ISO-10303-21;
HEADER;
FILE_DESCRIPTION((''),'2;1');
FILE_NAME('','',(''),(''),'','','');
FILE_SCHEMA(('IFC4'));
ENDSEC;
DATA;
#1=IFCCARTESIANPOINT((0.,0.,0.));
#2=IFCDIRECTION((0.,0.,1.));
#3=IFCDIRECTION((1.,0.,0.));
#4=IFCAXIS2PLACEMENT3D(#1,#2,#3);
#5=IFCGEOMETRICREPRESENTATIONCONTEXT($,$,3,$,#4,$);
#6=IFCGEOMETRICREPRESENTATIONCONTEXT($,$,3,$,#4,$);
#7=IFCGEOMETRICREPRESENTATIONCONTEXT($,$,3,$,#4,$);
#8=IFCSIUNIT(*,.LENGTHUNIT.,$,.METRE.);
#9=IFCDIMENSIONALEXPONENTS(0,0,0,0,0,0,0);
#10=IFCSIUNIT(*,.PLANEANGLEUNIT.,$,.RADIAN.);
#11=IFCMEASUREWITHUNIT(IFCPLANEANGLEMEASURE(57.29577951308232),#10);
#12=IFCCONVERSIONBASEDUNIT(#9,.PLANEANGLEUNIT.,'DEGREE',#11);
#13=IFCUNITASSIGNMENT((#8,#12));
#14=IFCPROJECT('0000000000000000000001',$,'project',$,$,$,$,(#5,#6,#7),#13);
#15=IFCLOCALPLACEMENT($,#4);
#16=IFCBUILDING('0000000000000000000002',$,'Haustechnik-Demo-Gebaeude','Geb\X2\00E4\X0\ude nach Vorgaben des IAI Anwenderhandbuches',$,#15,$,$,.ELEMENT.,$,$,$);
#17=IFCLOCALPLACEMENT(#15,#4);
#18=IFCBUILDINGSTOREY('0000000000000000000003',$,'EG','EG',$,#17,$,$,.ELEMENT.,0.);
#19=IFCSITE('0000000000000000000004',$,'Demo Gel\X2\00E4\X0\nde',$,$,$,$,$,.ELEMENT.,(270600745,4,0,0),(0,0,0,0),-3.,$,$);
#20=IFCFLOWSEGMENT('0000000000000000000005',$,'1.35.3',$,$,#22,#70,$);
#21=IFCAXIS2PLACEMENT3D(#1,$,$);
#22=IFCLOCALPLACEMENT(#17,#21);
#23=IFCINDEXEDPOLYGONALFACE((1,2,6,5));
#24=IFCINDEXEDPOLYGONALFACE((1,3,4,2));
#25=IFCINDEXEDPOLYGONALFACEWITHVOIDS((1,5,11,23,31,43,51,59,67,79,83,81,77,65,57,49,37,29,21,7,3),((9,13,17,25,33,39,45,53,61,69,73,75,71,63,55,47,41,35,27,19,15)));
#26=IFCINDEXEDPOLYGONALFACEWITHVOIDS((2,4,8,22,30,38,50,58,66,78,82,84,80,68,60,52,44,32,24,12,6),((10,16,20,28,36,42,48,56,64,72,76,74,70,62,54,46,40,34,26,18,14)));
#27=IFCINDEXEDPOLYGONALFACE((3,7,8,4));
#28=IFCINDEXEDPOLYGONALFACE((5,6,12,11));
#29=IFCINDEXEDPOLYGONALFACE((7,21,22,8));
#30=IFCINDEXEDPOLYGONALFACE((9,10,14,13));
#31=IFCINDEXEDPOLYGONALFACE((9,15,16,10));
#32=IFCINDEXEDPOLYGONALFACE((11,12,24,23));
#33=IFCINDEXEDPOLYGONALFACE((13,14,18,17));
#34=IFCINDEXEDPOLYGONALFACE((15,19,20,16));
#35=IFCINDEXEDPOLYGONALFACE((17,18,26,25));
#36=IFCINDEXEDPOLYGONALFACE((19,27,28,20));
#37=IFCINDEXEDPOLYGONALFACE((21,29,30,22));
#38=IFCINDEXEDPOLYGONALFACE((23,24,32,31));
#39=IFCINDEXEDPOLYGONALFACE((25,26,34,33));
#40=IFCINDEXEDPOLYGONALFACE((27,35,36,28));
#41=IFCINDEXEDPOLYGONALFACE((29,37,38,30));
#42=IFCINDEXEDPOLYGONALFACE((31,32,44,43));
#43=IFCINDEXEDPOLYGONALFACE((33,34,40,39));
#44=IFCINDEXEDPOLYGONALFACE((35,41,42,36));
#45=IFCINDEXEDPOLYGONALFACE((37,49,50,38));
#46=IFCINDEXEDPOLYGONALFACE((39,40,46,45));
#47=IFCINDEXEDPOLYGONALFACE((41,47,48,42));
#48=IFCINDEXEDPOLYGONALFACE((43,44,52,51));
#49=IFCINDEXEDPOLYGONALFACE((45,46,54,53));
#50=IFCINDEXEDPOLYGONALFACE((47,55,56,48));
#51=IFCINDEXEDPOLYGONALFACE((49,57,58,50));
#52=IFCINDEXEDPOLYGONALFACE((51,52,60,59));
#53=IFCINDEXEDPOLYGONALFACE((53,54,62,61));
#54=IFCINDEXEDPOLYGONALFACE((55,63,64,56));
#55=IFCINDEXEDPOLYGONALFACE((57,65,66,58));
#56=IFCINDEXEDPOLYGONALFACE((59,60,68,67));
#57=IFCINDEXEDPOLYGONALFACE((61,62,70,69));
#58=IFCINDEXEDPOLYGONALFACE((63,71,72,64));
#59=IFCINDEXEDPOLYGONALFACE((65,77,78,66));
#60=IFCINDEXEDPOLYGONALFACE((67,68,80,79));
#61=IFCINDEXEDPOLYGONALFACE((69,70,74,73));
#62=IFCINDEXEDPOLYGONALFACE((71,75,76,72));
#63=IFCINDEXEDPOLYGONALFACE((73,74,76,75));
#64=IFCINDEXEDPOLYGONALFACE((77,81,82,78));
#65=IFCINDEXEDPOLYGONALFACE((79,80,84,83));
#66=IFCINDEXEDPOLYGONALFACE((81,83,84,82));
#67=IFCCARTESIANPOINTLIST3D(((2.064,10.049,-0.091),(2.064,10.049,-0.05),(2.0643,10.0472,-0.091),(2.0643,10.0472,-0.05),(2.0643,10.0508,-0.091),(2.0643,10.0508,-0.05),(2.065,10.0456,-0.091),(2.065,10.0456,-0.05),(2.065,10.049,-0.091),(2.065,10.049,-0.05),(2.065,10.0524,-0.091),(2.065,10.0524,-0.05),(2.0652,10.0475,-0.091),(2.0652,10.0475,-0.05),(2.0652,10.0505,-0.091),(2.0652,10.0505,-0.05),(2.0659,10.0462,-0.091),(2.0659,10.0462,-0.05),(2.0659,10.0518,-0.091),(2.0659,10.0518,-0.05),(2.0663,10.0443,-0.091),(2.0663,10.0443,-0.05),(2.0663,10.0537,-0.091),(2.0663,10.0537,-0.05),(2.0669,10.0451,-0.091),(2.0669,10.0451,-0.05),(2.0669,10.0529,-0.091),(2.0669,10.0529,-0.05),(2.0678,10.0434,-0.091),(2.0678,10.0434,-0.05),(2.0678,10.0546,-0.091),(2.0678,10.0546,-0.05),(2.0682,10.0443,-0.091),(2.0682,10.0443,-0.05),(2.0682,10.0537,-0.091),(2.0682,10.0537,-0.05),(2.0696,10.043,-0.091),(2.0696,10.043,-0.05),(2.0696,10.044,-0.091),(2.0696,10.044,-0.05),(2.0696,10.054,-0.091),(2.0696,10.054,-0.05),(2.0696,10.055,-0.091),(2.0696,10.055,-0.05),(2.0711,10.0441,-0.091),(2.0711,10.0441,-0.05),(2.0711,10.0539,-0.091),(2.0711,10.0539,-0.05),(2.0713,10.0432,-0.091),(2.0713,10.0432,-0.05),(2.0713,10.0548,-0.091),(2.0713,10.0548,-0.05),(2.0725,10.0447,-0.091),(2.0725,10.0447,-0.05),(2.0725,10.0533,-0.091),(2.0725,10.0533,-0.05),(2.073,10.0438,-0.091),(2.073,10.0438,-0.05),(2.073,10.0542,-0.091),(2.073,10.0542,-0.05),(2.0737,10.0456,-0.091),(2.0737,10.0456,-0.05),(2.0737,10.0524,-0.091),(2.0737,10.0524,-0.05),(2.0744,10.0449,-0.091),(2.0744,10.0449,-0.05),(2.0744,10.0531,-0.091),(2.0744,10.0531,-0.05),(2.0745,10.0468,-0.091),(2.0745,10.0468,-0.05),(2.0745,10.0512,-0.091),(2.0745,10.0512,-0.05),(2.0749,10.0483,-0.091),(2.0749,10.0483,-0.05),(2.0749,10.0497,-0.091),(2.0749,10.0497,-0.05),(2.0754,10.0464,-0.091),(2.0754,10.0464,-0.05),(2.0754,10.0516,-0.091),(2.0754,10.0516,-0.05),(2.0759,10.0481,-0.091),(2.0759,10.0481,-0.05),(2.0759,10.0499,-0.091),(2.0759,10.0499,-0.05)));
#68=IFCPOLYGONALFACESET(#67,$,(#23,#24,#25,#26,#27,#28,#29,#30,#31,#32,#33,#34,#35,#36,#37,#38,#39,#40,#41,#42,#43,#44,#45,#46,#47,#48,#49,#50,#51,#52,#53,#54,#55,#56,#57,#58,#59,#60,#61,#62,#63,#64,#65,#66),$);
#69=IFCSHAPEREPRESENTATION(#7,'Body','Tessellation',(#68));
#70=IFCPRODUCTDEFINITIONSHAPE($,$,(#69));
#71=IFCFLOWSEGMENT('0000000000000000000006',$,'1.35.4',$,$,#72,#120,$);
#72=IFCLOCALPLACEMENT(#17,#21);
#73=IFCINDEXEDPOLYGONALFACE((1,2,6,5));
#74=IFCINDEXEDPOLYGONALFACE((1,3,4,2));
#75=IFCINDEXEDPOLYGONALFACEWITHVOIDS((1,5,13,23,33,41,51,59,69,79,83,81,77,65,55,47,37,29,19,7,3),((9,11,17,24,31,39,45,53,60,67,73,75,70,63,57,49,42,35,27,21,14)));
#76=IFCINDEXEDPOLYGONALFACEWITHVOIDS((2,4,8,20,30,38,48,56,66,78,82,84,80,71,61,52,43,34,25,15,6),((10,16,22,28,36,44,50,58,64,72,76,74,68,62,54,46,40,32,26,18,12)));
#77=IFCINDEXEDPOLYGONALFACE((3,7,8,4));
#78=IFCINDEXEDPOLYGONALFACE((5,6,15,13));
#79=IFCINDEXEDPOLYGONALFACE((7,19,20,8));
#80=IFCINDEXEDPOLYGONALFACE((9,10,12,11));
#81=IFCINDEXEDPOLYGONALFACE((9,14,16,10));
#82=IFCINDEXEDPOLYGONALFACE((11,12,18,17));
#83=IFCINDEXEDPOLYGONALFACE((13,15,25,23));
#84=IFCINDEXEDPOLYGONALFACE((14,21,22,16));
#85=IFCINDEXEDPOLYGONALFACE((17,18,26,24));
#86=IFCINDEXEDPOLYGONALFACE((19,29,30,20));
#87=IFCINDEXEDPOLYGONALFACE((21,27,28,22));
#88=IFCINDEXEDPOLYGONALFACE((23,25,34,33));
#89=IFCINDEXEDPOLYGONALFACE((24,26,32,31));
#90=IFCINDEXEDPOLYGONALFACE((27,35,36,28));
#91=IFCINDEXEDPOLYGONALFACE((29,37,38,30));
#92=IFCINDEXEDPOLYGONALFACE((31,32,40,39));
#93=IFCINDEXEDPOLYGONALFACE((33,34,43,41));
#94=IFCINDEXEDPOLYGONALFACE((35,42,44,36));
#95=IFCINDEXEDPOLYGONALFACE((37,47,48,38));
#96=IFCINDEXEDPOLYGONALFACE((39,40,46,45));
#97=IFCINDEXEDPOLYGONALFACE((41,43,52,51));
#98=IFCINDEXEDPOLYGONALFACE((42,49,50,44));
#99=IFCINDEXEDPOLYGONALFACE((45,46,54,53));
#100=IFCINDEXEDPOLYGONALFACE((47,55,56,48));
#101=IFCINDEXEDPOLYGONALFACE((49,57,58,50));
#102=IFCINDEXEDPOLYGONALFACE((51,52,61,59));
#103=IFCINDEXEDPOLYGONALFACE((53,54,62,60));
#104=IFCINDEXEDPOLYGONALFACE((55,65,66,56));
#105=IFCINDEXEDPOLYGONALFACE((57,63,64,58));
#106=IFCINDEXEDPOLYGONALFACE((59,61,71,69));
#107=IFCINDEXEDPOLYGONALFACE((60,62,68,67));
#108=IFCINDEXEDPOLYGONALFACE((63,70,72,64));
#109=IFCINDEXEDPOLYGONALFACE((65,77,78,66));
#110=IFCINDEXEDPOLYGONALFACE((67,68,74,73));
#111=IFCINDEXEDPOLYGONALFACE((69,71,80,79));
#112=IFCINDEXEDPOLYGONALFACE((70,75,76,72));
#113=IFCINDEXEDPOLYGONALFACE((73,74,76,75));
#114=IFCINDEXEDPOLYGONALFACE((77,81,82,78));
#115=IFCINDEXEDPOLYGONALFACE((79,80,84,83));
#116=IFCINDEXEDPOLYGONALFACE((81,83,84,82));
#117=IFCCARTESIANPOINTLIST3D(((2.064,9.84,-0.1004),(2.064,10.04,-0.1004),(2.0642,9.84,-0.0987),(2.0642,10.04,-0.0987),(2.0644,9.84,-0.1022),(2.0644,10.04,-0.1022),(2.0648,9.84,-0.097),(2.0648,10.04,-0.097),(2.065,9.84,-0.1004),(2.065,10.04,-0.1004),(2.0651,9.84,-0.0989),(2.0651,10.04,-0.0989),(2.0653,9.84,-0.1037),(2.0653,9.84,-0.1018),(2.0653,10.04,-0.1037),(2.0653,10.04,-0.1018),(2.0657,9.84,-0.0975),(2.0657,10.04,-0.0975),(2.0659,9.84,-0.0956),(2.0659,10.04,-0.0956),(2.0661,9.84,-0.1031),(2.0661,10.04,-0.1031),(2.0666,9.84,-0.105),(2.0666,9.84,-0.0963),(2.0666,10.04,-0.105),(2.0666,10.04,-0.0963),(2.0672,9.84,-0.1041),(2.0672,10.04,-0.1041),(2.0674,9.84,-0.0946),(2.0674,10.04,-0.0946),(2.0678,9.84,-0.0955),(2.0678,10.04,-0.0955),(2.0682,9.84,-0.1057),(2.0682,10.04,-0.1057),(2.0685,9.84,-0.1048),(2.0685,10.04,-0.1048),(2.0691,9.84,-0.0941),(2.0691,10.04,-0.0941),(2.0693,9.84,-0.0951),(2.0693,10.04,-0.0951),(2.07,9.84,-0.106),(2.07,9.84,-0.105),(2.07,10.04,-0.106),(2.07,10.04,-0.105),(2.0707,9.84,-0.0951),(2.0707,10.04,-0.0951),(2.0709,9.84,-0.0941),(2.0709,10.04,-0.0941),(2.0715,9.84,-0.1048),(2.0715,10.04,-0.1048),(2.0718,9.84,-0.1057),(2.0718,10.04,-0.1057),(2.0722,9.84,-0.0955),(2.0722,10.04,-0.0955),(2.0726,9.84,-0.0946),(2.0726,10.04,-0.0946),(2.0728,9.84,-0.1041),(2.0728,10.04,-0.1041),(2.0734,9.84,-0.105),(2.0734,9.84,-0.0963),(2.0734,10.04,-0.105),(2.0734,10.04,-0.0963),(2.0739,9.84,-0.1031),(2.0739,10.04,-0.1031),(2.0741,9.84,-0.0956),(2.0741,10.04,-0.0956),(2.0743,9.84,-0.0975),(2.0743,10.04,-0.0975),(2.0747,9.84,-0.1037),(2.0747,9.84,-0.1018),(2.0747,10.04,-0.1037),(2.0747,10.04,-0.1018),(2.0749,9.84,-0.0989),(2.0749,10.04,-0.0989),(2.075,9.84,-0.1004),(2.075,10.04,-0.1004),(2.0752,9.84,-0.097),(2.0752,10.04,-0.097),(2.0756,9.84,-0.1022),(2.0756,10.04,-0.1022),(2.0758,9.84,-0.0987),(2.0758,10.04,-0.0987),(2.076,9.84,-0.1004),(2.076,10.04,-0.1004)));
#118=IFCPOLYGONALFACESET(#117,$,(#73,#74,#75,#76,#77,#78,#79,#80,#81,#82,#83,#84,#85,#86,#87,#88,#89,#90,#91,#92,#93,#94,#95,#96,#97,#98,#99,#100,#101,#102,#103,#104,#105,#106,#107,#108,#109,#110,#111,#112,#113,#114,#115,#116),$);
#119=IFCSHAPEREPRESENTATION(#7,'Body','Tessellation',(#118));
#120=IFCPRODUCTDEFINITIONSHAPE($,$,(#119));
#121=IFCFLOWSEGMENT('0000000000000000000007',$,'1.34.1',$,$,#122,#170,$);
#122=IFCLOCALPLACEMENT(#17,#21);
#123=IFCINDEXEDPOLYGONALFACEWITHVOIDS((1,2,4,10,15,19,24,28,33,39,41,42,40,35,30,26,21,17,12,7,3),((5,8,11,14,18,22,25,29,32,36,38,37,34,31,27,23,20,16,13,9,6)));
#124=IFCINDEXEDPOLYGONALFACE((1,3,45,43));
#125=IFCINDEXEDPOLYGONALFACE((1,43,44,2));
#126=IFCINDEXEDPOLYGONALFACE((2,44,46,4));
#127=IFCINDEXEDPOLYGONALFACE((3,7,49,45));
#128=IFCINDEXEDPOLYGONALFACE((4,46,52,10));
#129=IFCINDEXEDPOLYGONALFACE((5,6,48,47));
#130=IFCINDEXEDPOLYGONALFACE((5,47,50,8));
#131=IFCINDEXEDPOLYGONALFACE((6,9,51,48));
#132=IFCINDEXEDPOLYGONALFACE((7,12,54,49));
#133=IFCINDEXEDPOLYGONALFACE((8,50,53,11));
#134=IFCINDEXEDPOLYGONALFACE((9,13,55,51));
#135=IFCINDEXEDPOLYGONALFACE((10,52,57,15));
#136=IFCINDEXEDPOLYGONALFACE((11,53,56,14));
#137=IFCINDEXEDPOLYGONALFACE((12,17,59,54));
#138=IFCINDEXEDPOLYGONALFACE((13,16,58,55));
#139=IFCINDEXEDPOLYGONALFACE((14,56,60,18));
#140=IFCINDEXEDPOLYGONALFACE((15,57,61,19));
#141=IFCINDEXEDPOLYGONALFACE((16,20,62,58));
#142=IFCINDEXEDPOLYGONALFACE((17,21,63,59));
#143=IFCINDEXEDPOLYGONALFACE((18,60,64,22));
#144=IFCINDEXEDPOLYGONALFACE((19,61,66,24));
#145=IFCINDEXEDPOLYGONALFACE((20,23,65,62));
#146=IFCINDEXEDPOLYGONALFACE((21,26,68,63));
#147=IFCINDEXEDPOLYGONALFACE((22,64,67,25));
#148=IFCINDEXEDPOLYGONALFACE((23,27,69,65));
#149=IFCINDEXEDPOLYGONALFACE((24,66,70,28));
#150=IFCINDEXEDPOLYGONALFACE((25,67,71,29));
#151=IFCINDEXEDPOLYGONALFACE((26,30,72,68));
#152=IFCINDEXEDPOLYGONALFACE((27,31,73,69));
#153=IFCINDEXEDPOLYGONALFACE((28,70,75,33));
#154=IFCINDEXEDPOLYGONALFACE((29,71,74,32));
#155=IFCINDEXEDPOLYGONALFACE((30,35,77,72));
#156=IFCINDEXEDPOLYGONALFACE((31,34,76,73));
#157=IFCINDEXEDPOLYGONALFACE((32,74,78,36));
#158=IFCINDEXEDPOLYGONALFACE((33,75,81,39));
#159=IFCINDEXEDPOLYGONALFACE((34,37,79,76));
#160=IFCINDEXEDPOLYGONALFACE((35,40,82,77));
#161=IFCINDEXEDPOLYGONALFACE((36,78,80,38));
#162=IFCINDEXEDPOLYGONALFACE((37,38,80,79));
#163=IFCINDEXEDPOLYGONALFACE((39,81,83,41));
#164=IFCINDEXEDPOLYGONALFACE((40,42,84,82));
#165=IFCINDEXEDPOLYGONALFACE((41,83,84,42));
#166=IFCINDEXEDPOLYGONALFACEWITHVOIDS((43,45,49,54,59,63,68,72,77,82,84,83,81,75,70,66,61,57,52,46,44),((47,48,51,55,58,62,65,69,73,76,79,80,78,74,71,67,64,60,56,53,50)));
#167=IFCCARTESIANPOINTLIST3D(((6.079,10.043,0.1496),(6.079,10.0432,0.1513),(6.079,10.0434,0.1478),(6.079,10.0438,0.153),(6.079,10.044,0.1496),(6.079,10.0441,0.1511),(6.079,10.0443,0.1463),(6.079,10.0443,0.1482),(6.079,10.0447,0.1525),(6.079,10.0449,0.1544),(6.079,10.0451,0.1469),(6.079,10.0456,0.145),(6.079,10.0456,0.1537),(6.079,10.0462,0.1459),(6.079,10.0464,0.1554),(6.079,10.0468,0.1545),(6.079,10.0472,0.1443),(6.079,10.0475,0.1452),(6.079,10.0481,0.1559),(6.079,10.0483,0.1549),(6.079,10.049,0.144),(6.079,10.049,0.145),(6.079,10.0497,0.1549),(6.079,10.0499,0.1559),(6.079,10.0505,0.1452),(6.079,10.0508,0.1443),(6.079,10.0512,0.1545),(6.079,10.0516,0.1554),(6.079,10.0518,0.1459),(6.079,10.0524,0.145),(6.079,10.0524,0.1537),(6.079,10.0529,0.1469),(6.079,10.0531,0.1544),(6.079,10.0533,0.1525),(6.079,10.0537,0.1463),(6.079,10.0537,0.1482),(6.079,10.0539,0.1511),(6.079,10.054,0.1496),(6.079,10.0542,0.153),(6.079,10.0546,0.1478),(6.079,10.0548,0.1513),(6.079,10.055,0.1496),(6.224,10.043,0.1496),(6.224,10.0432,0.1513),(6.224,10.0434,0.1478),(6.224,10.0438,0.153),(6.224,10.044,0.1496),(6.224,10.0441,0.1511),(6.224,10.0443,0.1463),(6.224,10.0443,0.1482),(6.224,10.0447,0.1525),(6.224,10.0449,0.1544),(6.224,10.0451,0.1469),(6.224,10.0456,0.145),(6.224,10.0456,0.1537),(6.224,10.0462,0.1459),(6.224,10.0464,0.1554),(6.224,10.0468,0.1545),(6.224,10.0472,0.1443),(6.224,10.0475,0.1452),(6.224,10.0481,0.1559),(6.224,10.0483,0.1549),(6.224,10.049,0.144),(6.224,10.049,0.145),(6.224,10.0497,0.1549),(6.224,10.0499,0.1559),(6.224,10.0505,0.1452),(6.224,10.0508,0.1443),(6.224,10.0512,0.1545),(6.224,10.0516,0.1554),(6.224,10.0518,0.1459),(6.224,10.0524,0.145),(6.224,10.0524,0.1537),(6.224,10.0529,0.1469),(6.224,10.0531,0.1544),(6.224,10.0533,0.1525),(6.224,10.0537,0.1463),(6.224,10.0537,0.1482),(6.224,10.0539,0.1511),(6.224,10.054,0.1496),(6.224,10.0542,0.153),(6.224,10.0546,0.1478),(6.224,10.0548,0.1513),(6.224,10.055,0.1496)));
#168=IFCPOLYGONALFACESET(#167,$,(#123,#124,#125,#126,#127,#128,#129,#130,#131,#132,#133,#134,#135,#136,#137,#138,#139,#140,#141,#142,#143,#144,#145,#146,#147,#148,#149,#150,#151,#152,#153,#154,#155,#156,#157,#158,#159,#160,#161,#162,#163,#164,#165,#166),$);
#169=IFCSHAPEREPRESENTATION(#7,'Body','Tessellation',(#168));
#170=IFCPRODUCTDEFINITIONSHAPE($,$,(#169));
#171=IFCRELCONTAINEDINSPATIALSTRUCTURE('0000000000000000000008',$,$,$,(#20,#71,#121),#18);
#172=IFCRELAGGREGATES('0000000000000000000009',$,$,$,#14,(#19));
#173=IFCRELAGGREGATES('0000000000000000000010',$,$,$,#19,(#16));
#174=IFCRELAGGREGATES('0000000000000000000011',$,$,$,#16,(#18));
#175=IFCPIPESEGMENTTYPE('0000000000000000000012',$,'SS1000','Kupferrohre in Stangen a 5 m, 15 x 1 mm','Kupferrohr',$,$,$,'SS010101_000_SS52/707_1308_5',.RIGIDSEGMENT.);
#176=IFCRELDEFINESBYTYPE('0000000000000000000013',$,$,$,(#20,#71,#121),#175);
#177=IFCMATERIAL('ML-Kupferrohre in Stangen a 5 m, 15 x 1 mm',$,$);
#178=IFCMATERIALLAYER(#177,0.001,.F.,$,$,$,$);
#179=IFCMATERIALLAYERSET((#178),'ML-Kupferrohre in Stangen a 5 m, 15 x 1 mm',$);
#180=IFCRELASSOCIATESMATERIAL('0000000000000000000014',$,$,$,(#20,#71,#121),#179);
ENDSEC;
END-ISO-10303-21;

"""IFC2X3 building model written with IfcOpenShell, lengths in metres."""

from ifc_helpers import new_model, entity, si_unit, converted_unit, frame, origin_with_axes, origin_2d_with_axis, place, context, project, spatial, hollow_circle, extrude, material, layer, layer_set, layer_usage, type_object, element, save


model = new_model("IFC2X3")

# Units and contexts
context_of_model_1 = context(None, 3, world=origin_with_axes())
context_of_model_2 = context(None, 3, world=origin_with_axes())
context_of_model_3 = context(None, 3, world=origin_with_axes())
ifc_project = project(units=[si_unit("LENGTHUNIT", "METRE"), converted_unit("PLANEANGLEUNIT", "DEGREE", entity("IfcPlaneAngleMeasure", 57.29577951308232), si_unit("PLANEANGLEUNIT", "RADIAN"), dimensions=[0, 0, 0, 0, 0, 0, 0])], contexts=[context_of_model_1, context_of_model_2, context_of_model_3])

# Site, building, storey
site = spatial("IfcSite", under=ifc_project, Name="Demo Gelände", CompositionType="ELEMENT", RefLatitude=(270600745, 4, 0, 0), RefLongitude=(0, 0, 0, 0), RefElevation=-3.0)
building_placement = place(None, origin_with_axes())
building = spatial("IfcBuilding", under=site, at=building_placement, Name="Haustechnik-Demo-Gebaeude", Description="Gebäude nach Vorgaben des IAI Anwenderhandbuches", CompositionType="ELEMENT")
storey_placement = place(building_placement, origin_with_axes())
storey = spatial("IfcBuildingStorey", under=building, at=storey_placement, Name="EG", Description="EG", CompositionType="ELEMENT", Elevation=0.0)

# Flow segments
ifc_material_1 = material(Name="ML-Kupferrohre in Stangen a 5 m, 15 x 1 mm")
ifc_layer_1 = layer(ifc_material_1, 0.001, ventilated=False)
ifc_layer_set_1 = layer_set([ifc_layer_1], Name="ML-Kupferrohre in Stangen a 5 m, 15 x 1 mm")
ifc_layer_usage_1 = layer_usage(ifc_layer_set_1, "AXIS2", "POSITIVE", 0.0)
pipe_segment_type_1 = type_object("IfcPipeSegmentType", Name="SS1000", Description="Kupferrohre in Stangen a 5 m, 15 x 1 mm", ApplicableOccurrence="Kupferrohr", ElementType="SS010101_000_SS52/707_1308_5", PredefinedType="RIGIDSEGMENT")
flow_segment_1_placement = place(storey_placement, frame((2.07, 10.049, -0.05), z_axis=(0.0, 0.0, -1.0), x_axis=(-1.0, 0.0, 0.0)))
element("IfcFlowSegment", 1, at=flow_segment_1_placement, inside=storey, type_object=pipe_segment_type_1, material=ifc_layer_usage_1, Name="1.35.3", context=context_of_model_3, shape_type="SweptSolid", body=[
    extrude(hollow_circle(Radius=0.006, WallThickness=0.001, at=origin_2d_with_axis()), origin_with_axes(), (0.0, 0.0, 1.0), 0.041),
])
flow_segment_2_placement = place(storey_placement, frame((2.07, 10.04, -0.1), z_axis=(0.0, -1.0, 0.0), x_axis=(0.0, 0.0, -1.0)))
element("IfcFlowSegment", 2, at=flow_segment_2_placement, inside=storey, type_object=pipe_segment_type_1, material=ifc_layer_usage_1, Name="1.35.4", context=context_of_model_3, shape_type="SweptSolid", body=[
    extrude(hollow_circle(Radius=0.006, WallThickness=0.001, at=origin_2d_with_axis()), origin_with_axes(), (0.0, 0.0, 1.0), 0.2),
])
flow_segment_3_placement = place(storey_placement, frame((6.224, 10.049, 0.15), z_axis=(-1.0, 0.0, 0.0), x_axis=(0.0, 0.0, -1.0)))
element("IfcFlowSegment", 3, at=flow_segment_3_placement, inside=storey, type_object=pipe_segment_type_1, material=ifc_layer_usage_1, Name="1.34.1", context=context_of_model_3, shape_type="SweptSolid", body=[
    extrude(hollow_circle(Radius=0.006, WallThickness=0.001, at=origin_2d_with_axis()), origin_with_axes(), (0.0, 0.0, 1.0), 0.145),
])

save(model, "model.ifc")
